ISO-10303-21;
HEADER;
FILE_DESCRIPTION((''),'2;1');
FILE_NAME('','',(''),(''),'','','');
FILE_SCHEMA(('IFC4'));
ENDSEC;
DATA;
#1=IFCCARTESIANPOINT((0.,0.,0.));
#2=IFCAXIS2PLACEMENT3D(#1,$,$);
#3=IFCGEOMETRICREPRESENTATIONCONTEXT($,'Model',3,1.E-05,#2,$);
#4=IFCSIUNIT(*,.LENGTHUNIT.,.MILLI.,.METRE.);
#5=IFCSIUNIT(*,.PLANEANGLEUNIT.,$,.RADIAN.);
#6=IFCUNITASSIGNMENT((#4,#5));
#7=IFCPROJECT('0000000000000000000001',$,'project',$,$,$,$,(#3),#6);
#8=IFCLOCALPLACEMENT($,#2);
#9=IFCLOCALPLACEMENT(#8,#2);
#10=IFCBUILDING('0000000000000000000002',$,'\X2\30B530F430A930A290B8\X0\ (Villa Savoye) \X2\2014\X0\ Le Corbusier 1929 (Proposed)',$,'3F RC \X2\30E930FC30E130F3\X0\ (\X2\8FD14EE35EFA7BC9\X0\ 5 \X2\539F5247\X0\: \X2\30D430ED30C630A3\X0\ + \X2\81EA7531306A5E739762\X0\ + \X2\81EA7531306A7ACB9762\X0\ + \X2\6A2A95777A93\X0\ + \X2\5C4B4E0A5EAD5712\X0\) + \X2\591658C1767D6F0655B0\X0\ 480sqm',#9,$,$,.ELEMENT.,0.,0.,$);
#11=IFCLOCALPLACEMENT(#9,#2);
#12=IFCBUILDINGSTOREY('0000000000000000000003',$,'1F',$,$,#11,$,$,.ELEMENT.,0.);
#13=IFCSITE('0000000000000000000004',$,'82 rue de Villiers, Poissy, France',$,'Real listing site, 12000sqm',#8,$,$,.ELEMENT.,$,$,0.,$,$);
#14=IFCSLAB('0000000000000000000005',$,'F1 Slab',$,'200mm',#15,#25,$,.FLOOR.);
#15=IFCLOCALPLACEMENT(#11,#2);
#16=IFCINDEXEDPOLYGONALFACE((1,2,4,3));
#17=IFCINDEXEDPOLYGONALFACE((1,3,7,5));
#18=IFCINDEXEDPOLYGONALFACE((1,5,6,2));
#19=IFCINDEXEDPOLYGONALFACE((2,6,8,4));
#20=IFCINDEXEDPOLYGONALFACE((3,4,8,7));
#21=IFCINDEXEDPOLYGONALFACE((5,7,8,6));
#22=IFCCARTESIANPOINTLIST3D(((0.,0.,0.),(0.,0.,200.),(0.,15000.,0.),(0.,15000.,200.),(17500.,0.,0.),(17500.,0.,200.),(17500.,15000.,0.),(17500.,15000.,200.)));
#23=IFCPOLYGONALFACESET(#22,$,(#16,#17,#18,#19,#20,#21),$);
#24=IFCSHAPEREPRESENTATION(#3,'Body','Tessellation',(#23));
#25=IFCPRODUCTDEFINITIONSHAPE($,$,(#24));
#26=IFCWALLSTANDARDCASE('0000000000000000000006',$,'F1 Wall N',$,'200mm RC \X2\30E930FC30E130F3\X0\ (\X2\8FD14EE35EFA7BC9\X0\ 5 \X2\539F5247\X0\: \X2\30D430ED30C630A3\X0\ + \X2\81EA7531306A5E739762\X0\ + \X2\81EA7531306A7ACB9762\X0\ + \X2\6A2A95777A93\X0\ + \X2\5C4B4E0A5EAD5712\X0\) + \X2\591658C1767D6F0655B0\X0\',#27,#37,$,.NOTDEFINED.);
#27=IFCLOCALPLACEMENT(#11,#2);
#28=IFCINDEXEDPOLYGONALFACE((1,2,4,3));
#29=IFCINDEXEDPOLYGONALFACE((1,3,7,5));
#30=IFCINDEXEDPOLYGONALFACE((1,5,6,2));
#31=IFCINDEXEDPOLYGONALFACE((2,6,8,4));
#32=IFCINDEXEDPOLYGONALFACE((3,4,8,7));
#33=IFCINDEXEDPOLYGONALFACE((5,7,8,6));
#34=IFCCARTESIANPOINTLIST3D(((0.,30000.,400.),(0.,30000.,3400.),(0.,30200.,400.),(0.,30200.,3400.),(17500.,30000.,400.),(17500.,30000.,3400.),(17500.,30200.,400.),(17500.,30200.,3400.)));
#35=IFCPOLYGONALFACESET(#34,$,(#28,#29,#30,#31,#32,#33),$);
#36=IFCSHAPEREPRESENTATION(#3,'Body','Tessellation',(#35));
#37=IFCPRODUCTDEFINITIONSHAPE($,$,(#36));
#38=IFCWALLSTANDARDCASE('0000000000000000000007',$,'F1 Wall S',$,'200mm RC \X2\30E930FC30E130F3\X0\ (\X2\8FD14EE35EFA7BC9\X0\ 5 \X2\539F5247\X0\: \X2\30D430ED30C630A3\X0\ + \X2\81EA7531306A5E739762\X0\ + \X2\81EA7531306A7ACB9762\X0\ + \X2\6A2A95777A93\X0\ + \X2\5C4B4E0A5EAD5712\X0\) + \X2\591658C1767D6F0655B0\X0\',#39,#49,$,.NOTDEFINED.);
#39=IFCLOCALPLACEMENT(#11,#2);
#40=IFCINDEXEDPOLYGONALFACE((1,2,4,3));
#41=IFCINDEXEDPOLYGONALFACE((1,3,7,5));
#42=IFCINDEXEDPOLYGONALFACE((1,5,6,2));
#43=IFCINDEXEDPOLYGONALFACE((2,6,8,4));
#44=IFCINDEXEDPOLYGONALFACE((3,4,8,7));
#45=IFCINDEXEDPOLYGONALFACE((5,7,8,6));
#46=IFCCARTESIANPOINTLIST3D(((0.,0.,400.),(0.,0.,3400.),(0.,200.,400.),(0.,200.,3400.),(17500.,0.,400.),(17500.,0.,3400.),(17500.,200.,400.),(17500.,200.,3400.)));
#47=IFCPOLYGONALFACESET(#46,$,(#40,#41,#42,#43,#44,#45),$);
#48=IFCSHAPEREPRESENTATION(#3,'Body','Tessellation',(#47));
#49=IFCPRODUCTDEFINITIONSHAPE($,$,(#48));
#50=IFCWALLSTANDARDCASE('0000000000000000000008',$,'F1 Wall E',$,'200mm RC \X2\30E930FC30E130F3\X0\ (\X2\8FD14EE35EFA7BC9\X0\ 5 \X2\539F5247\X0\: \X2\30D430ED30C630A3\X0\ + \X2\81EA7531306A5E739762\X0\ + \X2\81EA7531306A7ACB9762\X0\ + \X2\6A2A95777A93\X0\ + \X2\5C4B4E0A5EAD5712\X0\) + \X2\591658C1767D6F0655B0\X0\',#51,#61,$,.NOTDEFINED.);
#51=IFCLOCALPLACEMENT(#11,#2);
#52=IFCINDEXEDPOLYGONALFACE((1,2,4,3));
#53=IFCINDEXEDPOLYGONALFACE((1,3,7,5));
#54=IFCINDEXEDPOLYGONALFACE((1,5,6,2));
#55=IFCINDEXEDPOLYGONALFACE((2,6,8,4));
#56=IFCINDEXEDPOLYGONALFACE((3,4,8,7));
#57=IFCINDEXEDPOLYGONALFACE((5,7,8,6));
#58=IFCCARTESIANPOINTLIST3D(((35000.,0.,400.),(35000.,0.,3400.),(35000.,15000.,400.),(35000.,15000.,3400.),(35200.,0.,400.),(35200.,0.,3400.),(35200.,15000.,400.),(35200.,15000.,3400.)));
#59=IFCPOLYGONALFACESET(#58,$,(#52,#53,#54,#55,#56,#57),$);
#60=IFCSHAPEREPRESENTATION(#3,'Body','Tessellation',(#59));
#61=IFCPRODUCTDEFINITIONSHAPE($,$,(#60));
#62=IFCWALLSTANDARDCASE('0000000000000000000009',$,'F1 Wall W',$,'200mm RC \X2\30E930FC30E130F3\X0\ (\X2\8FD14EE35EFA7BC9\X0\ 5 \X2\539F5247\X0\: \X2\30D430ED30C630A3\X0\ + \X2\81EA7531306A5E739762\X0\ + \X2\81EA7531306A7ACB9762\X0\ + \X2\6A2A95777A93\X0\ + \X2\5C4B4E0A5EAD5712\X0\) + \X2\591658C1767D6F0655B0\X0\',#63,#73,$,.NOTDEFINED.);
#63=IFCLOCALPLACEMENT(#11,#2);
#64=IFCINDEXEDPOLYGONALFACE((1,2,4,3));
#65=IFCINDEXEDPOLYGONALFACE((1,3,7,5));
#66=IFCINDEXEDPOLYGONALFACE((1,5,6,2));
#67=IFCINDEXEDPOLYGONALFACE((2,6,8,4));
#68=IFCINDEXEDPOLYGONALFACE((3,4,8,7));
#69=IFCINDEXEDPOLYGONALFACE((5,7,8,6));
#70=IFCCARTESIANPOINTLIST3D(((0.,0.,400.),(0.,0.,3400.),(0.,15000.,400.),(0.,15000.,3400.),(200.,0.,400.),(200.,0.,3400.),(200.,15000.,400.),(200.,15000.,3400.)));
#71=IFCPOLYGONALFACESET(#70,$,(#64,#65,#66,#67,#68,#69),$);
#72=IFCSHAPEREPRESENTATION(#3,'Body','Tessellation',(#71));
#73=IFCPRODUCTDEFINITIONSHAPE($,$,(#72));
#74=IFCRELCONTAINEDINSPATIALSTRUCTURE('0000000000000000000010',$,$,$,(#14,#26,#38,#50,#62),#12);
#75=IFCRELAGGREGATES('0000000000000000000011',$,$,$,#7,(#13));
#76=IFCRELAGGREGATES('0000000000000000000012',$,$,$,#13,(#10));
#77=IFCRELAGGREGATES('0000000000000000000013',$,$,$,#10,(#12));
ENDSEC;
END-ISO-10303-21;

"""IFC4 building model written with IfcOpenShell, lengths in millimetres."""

from ifc_helpers import new_model, si_unit, frame, frame_2d, origin, place, context, project, spatial, rectangle, extrude, element, save


model = new_model("IFC4")

# Units and contexts
model_context = context("Model", 3, precision=1e-05, world=origin())
ifc_project = project(units=[si_unit("LENGTHUNIT", "METRE", prefix="MILLI"), si_unit("PLANEANGLEUNIT", "RADIAN")], contexts=[model_context])

# Site, building, storey
site_placement = place(None, origin())
site = spatial("IfcSite", under=ifc_project, at=site_placement, Name="82 rue de Villiers, Poissy, France", ObjectType="Real listing site, 12000sqm", CompositionType="ELEMENT", RefElevation=0.0)
building_placement = place(site_placement, origin())
building = spatial("IfcBuilding", under=site, at=building_placement, Name="サヴォア邸 (Villa Savoye) — Le Corbusier 1929 (Proposed)", ObjectType="3F RC ラーメン (近代建築 5 原則: ピロティ + 自由な平面 + 自由な立面 + 横長窓 + 屋上庭園) + 外壁白漆喰 480sqm", CompositionType="ELEMENT", ElevationOfRefHeight=0.0, ElevationOfTerrain=0.0)
storey_placement = place(building_placement, origin())
storey = spatial("IfcBuildingStorey", under=building, at=storey_placement, Name="1F", CompositionType="ELEMENT", Elevation=0.0)

# Slab
slab_placement = place(storey_placement, origin())
element("IfcSlab", 1, at=slab_placement, inside=storey, Name="F1 Slab", ObjectType="200mm", PredefinedType="FLOOR", context=model_context, shape_type="SweptSolid", body=[
    extrude(rectangle(XDim=17500.0, YDim=15000.0, at=frame_2d((8750.0, 7500.0))), origin(), (0.0, 0.0, 1.0), 200.0),
])

# Walls
wall_1_placement = place(storey_placement, frame((0.0, 15000.0, 200.0)))
element("IfcWallStandardCase", 2, at=wall_1_placement, inside=storey, Name="F1 Wall N", ObjectType="200mm RC ラーメン (近代建築 5 原則: ピロティ + 自由な平面 + 自由な立面 + 横長窓 + 屋上庭園) + 外壁白漆喰", PredefinedType="NOTDEFINED", context=model_context, shape_type="SweptSolid", body=[
    extrude(rectangle(XDim=17500.0, YDim=200.0, at=frame_2d((8750.0, 100.0))), frame((0.0, 15000.0, 200.0)), (0.0, 0.0, 1.0), 3000.0),
])
wall_2_placement = place(storey_placement, frame((0.0, 0.0, 200.0)))
element("IfcWallStandardCase", 3, at=wall_2_placement, inside=storey, Name="F1 Wall S", ObjectType="200mm RC ラーメン (近代建築 5 原則: ピロティ + 自由な平面 + 自由な立面 + 横長窓 + 屋上庭園) + 外壁白漆喰", PredefinedType="NOTDEFINED", context=model_context, shape_type="SweptSolid", body=[
    extrude(rectangle(XDim=17500.0, YDim=200.0, at=frame_2d((8750.0, 100.0))), frame((0.0, 0.0, 200.0)), (0.0, 0.0, 1.0), 3000.0),
])
wall_3_placement = place(storey_placement, frame((17500.0, 0.0, 200.0)))
element("IfcWallStandardCase", 4, at=wall_3_placement, inside=storey, Name="F1 Wall E", ObjectType="200mm RC ラーメン (近代建築 5 原則: ピロティ + 自由な平面 + 自由な立面 + 横長窓 + 屋上庭園) + 外壁白漆喰", PredefinedType="NOTDEFINED", context=model_context, shape_type="SweptSolid", body=[
    extrude(rectangle(XDim=200.0, YDim=15000.0, at=frame_2d((100.0, 7500.0))), frame((17500.0, 0.0, 200.0)), (0.0, 0.0, 1.0), 3000.0),
])
wall_4_placement = place(storey_placement, frame((0.0, 0.0, 200.0)))
element("IfcWallStandardCase", 5, at=wall_4_placement, inside=storey, Name="F1 Wall W", ObjectType="200mm RC ラーメン (近代建築 5 原則: ピロティ + 自由な平面 + 自由な立面 + 横長窓 + 屋上庭園) + 外壁白漆喰", PredefinedType="NOTDEFINED", context=model_context, shape_type="SweptSolid", body=[
    extrude(rectangle(XDim=200.0, YDim=15000.0, at=frame_2d((100.0, 7500.0))), frame((0.0, 0.0, 200.0)), (0.0, 0.0, 1.0), 3000.0),
])

save(model, "model.ifc")
